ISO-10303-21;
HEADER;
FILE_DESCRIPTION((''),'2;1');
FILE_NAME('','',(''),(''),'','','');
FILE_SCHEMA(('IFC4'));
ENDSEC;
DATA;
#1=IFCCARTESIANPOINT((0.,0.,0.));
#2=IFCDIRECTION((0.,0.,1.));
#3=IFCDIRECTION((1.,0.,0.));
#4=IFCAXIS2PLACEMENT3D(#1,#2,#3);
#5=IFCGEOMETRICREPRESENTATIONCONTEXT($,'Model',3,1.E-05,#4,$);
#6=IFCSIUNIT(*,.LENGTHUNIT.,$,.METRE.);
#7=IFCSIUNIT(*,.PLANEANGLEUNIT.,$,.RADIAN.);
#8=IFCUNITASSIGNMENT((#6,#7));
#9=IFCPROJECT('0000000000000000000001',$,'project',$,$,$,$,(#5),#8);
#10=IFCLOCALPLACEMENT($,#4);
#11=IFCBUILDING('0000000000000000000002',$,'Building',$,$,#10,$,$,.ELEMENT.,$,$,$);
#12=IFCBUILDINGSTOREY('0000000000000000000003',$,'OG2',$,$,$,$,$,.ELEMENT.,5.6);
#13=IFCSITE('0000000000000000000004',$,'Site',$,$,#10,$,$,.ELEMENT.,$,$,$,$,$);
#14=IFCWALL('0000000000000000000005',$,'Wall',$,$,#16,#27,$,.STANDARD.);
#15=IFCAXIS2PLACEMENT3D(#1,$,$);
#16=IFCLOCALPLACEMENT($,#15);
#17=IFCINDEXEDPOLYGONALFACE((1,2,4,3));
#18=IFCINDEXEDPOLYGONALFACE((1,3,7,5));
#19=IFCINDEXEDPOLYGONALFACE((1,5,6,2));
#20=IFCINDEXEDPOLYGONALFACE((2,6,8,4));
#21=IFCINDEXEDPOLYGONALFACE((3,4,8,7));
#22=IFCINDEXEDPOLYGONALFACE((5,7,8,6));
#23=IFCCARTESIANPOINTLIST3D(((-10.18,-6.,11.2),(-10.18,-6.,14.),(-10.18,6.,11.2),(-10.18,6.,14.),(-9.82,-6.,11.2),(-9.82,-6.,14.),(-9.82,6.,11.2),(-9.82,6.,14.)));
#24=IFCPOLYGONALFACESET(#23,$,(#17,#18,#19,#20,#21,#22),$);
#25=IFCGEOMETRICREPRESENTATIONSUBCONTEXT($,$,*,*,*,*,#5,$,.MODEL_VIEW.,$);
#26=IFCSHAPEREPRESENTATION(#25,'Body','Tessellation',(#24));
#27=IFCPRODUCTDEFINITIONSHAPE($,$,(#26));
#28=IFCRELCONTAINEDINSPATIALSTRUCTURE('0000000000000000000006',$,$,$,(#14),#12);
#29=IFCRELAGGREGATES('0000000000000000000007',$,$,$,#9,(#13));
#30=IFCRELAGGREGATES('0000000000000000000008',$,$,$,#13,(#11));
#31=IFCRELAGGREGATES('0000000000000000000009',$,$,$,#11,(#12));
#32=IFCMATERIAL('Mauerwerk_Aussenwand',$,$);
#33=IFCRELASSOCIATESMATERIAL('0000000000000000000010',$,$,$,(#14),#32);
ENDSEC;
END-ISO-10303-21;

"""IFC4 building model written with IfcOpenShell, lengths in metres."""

from ifc_helpers import new_model, si_unit, frame, frame_2d, origin, origin_with_axes, place, context, subcontext, project, spatial, rectangle, extrude, material, element, save


model = new_model("IFC4")

# Units and contexts
model_context = context("Model", 3, precision=1e-05, world=origin_with_axes())
sub_context = subcontext(model_context, None, None, "MODEL_VIEW")
ifc_project = project(units=[si_unit("LENGTHUNIT", "METRE"), si_unit("PLANEANGLEUNIT", "RADIAN")], contexts=[model_context])

# Site, building, storey
placement_1 = place(None, origin_with_axes())
site = spatial("IfcSite", under=ifc_project, at=placement_1, Name="Site", CompositionType="ELEMENT")
building = spatial("IfcBuilding", under=site, at=placement_1, Name="Building", CompositionType="ELEMENT")
storey = spatial("IfcBuildingStorey", under=building, Name="OG2", CompositionType="ELEMENT", Elevation=5.6)

# Wall
ifc_material = material(Name="Mauerwerk_Aussenwand")
placement_2 = place(None, origin_with_axes())
placement_3 = place(placement_2, frame((0.0, 0.0, 5.6)))
wall_placement = place(placement_3, frame((-10.0, -6.0, 5.6), x_axis=(0.0, 1.0, 0.0)))
element("IfcWall", 1, at=wall_placement, inside=storey, material=ifc_material, Name="Wall", PredefinedType="STANDARD", context=sub_context, shape_type="SweptSolid", body=[
    extrude(rectangle(XDim=12.0, YDim=0.36, at=frame_2d((6.0, 0.0))), origin(), (0.0, 0.0, 1.0), 2.8),
])

save(model, "model.ifc")
